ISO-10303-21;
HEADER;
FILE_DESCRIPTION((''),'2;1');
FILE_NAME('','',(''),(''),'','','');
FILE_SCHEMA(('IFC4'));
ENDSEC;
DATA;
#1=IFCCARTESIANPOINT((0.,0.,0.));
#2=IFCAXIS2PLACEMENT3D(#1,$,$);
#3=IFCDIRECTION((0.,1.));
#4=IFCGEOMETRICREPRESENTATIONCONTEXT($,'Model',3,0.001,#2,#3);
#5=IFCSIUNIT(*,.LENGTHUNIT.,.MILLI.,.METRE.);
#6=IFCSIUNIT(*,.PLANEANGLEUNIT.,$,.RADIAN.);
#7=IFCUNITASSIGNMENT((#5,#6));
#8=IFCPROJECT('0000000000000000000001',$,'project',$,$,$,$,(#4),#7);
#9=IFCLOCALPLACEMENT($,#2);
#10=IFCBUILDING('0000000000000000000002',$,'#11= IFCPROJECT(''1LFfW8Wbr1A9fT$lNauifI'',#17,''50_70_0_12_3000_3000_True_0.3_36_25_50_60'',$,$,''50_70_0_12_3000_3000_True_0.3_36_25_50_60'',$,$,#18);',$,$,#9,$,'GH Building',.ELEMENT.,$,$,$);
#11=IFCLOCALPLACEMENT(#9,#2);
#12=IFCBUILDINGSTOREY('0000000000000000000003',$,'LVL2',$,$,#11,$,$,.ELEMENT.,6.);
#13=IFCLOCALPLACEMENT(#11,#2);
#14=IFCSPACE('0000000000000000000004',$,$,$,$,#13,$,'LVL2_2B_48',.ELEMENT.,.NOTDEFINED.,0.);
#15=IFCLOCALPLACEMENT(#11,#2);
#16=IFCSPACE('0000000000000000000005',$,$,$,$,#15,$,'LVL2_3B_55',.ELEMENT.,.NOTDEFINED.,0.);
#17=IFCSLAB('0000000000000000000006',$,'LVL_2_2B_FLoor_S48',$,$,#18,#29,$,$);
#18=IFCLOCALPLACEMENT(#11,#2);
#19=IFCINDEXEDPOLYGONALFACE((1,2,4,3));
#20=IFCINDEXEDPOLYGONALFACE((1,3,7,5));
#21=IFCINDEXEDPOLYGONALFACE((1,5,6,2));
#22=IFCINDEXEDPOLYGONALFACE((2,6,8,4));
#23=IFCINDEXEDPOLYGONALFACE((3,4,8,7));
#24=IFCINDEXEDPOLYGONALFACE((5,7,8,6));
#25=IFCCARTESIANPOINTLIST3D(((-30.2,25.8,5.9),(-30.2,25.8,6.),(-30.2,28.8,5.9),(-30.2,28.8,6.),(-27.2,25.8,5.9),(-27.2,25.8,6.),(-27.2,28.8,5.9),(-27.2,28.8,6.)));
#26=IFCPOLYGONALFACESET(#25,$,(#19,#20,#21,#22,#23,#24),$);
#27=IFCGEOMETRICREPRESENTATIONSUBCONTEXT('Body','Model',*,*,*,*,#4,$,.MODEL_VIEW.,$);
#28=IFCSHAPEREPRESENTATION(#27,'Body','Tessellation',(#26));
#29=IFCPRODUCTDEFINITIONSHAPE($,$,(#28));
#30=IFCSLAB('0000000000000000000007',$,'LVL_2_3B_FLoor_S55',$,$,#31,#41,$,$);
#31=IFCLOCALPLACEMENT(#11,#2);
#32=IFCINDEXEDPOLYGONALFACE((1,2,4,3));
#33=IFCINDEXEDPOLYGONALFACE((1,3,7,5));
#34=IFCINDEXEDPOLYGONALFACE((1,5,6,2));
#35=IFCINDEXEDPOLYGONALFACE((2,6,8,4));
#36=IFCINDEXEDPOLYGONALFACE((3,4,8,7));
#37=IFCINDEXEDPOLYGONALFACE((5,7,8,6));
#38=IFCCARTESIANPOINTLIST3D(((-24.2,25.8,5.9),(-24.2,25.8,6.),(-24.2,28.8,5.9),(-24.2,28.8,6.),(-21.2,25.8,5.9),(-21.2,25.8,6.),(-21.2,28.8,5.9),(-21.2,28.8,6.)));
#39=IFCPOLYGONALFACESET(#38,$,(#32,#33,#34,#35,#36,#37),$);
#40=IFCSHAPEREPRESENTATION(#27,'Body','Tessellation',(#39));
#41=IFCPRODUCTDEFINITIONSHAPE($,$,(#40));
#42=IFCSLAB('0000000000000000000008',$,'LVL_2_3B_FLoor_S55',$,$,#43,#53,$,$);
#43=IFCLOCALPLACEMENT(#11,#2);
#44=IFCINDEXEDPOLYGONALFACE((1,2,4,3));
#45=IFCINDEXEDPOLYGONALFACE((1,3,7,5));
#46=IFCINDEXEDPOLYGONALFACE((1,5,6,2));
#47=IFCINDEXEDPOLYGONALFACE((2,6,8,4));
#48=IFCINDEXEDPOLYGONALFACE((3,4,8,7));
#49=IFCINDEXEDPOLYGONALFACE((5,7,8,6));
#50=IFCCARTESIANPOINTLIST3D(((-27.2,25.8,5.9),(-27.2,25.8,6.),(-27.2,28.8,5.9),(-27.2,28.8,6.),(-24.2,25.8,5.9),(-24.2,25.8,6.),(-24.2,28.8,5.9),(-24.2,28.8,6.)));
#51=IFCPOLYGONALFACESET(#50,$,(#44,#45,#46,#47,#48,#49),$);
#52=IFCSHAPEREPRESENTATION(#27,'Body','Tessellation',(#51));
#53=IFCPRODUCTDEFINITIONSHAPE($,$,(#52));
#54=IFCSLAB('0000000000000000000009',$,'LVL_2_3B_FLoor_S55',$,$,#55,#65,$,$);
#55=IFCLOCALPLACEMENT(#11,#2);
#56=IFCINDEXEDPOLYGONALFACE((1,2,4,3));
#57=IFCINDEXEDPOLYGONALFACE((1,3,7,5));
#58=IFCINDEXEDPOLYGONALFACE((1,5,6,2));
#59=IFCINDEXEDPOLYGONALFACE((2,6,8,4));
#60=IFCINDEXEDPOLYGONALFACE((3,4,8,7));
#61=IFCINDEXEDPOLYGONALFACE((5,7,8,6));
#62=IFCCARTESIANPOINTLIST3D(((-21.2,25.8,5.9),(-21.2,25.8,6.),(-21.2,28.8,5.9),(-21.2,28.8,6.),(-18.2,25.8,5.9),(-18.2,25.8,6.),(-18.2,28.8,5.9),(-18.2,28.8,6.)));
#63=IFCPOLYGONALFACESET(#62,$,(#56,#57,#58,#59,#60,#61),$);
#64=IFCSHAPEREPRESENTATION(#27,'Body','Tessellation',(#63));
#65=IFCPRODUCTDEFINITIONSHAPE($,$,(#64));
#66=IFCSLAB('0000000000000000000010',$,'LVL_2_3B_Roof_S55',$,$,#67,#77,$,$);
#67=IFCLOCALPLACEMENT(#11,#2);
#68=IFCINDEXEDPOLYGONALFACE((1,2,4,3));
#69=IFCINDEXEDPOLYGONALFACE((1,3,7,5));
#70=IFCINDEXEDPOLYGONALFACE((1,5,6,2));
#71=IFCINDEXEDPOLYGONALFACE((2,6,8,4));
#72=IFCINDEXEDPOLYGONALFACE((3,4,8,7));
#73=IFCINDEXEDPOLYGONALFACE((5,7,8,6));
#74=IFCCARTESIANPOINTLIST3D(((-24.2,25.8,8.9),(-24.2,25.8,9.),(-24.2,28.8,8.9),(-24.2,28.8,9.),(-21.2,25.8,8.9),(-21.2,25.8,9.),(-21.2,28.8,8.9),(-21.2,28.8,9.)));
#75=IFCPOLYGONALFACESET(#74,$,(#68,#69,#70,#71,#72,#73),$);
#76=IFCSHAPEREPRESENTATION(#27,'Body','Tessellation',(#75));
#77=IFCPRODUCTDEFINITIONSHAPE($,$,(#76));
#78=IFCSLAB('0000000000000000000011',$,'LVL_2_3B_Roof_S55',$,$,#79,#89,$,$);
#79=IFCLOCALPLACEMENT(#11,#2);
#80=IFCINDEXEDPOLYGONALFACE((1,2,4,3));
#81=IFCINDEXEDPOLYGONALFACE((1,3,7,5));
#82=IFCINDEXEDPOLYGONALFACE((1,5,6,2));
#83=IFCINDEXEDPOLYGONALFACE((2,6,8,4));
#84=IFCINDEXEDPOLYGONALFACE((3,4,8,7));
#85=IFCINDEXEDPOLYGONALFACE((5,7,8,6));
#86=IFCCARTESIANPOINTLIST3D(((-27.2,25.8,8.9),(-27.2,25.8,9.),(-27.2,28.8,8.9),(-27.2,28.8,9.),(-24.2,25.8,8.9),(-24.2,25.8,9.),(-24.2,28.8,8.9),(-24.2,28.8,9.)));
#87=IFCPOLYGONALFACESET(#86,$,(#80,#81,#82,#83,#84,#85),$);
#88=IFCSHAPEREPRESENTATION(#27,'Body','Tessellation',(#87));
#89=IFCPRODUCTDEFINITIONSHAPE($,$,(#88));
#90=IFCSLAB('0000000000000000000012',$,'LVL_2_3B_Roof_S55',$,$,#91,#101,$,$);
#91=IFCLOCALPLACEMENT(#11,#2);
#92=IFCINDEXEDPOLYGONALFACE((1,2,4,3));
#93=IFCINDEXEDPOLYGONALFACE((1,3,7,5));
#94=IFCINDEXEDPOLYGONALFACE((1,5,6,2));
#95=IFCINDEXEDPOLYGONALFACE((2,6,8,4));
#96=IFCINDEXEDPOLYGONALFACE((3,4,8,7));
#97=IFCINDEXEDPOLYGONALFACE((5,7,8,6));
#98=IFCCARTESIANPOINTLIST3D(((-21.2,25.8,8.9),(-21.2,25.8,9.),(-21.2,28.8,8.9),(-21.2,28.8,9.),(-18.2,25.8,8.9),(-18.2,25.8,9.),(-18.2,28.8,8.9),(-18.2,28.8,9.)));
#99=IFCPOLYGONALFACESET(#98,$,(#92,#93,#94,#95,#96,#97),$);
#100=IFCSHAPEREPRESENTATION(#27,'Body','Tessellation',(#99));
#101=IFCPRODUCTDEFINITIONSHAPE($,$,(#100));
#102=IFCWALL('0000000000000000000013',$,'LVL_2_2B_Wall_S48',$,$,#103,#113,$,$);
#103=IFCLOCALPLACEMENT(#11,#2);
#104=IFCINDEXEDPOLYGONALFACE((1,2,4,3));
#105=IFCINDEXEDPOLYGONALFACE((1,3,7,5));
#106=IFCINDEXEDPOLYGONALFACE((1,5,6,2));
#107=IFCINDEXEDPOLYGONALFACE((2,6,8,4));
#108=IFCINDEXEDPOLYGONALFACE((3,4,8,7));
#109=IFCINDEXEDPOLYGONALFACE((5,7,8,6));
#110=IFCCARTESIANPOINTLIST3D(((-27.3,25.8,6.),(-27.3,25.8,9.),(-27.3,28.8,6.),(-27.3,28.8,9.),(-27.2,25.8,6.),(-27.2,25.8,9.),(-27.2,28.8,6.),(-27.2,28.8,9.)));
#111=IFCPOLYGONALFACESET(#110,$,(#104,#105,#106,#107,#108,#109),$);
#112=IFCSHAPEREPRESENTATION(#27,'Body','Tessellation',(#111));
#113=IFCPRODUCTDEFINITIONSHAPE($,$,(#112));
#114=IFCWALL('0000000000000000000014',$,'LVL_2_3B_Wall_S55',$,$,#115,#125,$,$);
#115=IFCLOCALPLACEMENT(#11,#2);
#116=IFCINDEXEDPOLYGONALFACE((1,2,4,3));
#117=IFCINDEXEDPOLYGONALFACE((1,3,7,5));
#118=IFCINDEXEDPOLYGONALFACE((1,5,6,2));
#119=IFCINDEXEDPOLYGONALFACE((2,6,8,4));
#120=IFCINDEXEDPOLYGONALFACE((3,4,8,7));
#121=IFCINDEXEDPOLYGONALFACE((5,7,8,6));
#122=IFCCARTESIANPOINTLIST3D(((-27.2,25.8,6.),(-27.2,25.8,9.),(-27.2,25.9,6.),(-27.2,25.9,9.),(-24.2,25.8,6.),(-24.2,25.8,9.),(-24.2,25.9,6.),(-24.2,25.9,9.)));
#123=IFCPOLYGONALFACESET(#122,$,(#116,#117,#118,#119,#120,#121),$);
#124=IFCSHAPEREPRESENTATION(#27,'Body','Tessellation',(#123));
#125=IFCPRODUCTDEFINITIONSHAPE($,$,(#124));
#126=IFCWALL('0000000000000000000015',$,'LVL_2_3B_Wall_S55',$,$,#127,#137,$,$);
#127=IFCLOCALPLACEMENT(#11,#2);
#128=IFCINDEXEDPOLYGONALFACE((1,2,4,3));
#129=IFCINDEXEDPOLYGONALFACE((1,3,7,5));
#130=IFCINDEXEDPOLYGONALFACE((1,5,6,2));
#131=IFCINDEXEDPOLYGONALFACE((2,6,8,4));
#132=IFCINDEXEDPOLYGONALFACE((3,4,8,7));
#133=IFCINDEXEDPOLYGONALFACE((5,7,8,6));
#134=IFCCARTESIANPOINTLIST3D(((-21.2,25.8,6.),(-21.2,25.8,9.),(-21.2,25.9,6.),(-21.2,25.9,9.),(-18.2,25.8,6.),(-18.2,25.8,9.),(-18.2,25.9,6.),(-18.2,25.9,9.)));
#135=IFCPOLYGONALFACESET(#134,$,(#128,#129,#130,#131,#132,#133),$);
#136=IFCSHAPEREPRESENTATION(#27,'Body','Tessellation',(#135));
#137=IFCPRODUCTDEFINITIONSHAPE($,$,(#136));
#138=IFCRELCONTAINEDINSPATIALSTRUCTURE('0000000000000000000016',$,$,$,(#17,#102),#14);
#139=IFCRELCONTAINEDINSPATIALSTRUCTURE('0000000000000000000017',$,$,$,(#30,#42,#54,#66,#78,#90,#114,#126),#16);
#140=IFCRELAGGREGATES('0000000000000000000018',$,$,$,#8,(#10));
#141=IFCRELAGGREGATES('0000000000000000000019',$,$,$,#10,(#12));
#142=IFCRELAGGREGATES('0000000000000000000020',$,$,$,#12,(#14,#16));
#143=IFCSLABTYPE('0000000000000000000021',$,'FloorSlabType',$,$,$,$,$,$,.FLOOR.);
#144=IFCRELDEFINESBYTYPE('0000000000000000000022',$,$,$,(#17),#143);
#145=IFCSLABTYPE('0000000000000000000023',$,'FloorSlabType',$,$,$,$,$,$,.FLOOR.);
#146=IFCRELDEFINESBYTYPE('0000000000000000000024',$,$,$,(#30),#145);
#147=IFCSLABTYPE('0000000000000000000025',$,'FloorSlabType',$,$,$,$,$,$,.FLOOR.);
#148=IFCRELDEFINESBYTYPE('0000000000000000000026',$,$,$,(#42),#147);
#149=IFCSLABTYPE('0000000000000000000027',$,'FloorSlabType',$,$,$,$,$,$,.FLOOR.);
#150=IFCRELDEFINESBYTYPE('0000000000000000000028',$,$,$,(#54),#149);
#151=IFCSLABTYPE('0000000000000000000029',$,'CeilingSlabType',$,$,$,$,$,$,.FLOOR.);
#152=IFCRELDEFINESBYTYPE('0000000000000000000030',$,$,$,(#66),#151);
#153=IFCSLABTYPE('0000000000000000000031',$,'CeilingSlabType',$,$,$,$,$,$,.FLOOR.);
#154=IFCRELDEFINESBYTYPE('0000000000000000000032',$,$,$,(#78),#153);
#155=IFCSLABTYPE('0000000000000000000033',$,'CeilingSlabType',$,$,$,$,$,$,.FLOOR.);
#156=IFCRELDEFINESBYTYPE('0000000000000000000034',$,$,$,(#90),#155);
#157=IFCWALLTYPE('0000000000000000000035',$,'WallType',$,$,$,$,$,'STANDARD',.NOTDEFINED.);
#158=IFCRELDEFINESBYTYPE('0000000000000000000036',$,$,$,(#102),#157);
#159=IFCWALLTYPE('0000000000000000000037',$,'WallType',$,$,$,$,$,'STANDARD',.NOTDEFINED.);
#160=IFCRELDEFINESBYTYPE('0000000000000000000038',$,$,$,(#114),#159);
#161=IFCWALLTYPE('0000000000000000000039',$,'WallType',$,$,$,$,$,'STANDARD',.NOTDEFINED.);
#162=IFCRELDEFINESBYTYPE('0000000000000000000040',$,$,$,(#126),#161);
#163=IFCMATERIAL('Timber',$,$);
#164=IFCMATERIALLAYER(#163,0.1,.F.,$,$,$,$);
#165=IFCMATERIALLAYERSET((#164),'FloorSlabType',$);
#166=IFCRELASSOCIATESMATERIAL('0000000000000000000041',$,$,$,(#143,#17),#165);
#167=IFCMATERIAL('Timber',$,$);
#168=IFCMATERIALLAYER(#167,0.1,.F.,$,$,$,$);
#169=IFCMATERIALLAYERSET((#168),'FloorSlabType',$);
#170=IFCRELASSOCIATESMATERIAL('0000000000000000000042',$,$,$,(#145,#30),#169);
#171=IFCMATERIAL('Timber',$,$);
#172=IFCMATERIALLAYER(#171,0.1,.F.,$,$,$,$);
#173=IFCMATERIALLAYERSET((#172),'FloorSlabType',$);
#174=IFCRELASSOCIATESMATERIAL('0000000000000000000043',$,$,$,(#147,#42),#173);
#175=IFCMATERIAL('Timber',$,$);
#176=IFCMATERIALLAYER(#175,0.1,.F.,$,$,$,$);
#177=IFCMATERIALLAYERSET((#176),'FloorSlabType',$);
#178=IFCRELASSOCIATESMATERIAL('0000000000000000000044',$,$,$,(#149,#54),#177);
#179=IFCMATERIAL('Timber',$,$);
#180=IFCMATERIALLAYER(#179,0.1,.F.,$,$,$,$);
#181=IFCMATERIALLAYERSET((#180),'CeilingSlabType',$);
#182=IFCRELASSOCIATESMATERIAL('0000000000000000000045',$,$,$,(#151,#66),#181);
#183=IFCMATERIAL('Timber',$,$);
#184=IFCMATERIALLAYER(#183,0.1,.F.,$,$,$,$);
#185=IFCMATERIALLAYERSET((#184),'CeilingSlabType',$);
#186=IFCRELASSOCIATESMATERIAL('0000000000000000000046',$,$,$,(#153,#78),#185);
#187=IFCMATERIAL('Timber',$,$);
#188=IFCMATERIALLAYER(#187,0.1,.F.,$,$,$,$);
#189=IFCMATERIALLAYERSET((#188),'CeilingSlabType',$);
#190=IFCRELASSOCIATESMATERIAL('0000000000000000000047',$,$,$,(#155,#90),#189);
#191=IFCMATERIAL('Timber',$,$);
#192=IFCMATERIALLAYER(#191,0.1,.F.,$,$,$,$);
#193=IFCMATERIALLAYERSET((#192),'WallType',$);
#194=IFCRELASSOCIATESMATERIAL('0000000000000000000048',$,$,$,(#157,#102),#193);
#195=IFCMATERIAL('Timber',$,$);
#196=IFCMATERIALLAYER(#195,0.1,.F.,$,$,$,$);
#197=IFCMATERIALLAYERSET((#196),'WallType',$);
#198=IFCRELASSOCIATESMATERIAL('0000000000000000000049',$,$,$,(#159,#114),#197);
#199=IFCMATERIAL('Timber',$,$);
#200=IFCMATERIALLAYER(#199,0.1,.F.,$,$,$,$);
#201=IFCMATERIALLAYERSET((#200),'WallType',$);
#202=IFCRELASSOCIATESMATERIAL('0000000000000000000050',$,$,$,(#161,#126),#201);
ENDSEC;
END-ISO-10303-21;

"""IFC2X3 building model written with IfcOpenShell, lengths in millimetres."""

from ifc_helpers import new_model, si_unit, direction, frame, frame_2d, origin, place, context, subcontext, project, spatial, rectangle, extrude, material, layer, layer_set, layer_usage, type_object, element, save


model = new_model("IFC2X3")

# Units and contexts
model_context = context("Model", 3, precision=0.001, world=origin(), true_north=direction((0.0, 1.0)))
body_context = subcontext(model_context, "Body", "Model", "MODEL_VIEW")
ifc_project = project(units=[si_unit("LENGTHUNIT", "METRE", prefix="MILLI"), si_unit("PLANEANGLEUNIT", "RADIAN")], contexts=[model_context])

# Building, storey
building_placement = place(None, origin())
building = spatial("IfcBuilding", under=ifc_project, at=building_placement, Name="#11= IFCPROJECT('1LFfW8Wbr1A9fT$lNauifI',#17,'50_70_0_12_3000_3000_True_0.3_36_25_50_60',$,$,'50_70_0_12_3000_3000_True_0.3_36_25_50_60',$,$,#18);", LongName="GH Building", CompositionType="ELEMENT")
storey_placement = place(building_placement, origin())
storey = spatial("IfcBuildingStorey", under=building, at=storey_placement, Name="LVL2", CompositionType="ELEMENT", Elevation=6.0)

# Shared definitions
space_1_placement = place(storey_placement, origin())
space_1 = spatial("IfcSpace", under=storey, at=space_1_placement, LongName="LVL2_2B_48", CompositionType="ELEMENT", InteriorOrExteriorSpace="NOTDEFINED", ElevationWithFlooring=0.0)

# Slab
ifc_material_1 = material(Name="Timber")
ifc_layer_1 = layer(ifc_material_1, 0.1, ventilated=False)
ifc_layer_set_1 = layer_set([ifc_layer_1], Name="FloorSlabType")
ifc_layer_usage_1 = layer_usage(ifc_layer_set_1, "AXIS3", "NEGATIVE", -0.1)
slab_type_1 = type_object("IfcSlabType", Name="FloorSlabType", PredefinedType="FLOOR", material=ifc_layer_set_1)
slab_1_placement = place(space_1_placement, frame((-27.2, 28.8, 5.9), z_axis=(0.0, 0.0, 1.0), x_axis=(-1.0, 0.0, 0.0)))
element("IfcSlab", 1, at=slab_1_placement, inside=space_1, type_object=slab_type_1, material=ifc_layer_usage_1, Name="LVL_2_2B_FLoor_S48", context=body_context, shape_type="SweptSolid", body=[
    extrude(rectangle(XDim=3.0, YDim=3.0, at=frame_2d((1.5, 1.5))), origin(), (0.0, 0.0, 1.0), 0.1),
])

# Shared definitions
space_2_placement = place(storey_placement, origin())
space_2 = spatial("IfcSpace", under=storey, at=space_2_placement, LongName="LVL2_3B_55", CompositionType="ELEMENT", InteriorOrExteriorSpace="NOTDEFINED", ElevationWithFlooring=0.0)

# Slabs
ifc_material_2 = material(Name="Timber")
ifc_layer_2 = layer(ifc_material_2, 0.1, ventilated=False)
ifc_layer_set_2 = layer_set([ifc_layer_2], Name="FloorSlabType")
ifc_layer_usage_2 = layer_usage(ifc_layer_set_2, "AXIS3", "NEGATIVE", -0.1)
slab_type_2 = type_object("IfcSlabType", Name="FloorSlabType", PredefinedType="FLOOR", material=ifc_layer_set_2)
slab_2_placement = place(space_2_placement, frame((-21.2, 28.8, 5.9), z_axis=(0.0, 0.0, 1.0), x_axis=(-1.0, 0.0, 0.0)))
element("IfcSlab", 2, at=slab_2_placement, inside=space_2, type_object=slab_type_2, material=ifc_layer_usage_2, Name="LVL_2_3B_FLoor_S55", context=body_context, shape_type="SweptSolid", body=[
    extrude(rectangle(XDim=3.0, YDim=3.0, at=frame_2d((1.5, 1.5))), origin(), (0.0, 0.0, 1.0), 0.1),
])
ifc_material_3 = material(Name="Timber")
ifc_layer_3 = layer(ifc_material_3, 0.1, ventilated=False)
ifc_layer_set_3 = layer_set([ifc_layer_3], Name="FloorSlabType")
ifc_layer_usage_3 = layer_usage(ifc_layer_set_3, "AXIS3", "NEGATIVE", -0.1)
slab_type_3 = type_object("IfcSlabType", Name="FloorSlabType", PredefinedType="FLOOR", material=ifc_layer_set_3)
slab_3_placement = place(space_2_placement, frame((-24.2, 28.8, 5.9), z_axis=(0.0, 0.0, 1.0), x_axis=(-1.0, 0.0, 0.0)))
element("IfcSlab", 3, at=slab_3_placement, inside=space_2, type_object=slab_type_3, material=ifc_layer_usage_3, Name="LVL_2_3B_FLoor_S55", context=body_context, shape_type="SweptSolid", body=[
    extrude(rectangle(XDim=3.0, YDim=3.0, at=frame_2d((1.5, 1.5))), origin(), (0.0, 0.0, 1.0), 0.1),
])
ifc_material_4 = material(Name="Timber")
ifc_layer_4 = layer(ifc_material_4, 0.1, ventilated=False)
ifc_layer_set_4 = layer_set([ifc_layer_4], Name="FloorSlabType")
ifc_layer_usage_4 = layer_usage(ifc_layer_set_4, "AXIS3", "NEGATIVE", -0.1)
slab_type_4 = type_object("IfcSlabType", Name="FloorSlabType", PredefinedType="FLOOR", material=ifc_layer_set_4)
slab_4_placement = place(space_2_placement, frame((-18.2, 28.8, 5.9), z_axis=(0.0, 0.0, 1.0), x_axis=(-1.0, 0.0, 0.0)))
element("IfcSlab", 4, at=slab_4_placement, inside=space_2, type_object=slab_type_4, material=ifc_layer_usage_4, Name="LVL_2_3B_FLoor_S55", context=body_context, shape_type="SweptSolid", body=[
    extrude(rectangle(XDim=3.0, YDim=3.0, at=frame_2d((1.5, 1.5))), origin(), (0.0, 0.0, 1.0), 0.1),
])
ifc_material_5 = material(Name="Timber")
ifc_layer_5 = layer(ifc_material_5, 0.1, ventilated=False)
ifc_layer_set_5 = layer_set([ifc_layer_5], Name="CeilingSlabType")
ifc_layer_usage_5 = layer_usage(ifc_layer_set_5, "AXIS3", "NEGATIVE", -0.1)
slab_type_5 = type_object("IfcSlabType", Name="CeilingSlabType", PredefinedType="FLOOR", material=ifc_layer_set_5)
slab_5_placement = place(space_2_placement, frame((-21.2, 28.8, 8.9), z_axis=(0.0, 0.0, 1.0), x_axis=(-1.0, 0.0, 0.0)))
element("IfcSlab", 5, at=slab_5_placement, inside=space_2, type_object=slab_type_5, material=ifc_layer_usage_5, Name="LVL_2_3B_Roof_S55", context=body_context, shape_type="SweptSolid", body=[
    extrude(rectangle(XDim=3.0, YDim=3.0, at=frame_2d((1.5, 1.5))), origin(), (0.0, 0.0, 1.0), 0.1),
])
ifc_material_6 = material(Name="Timber")
ifc_layer_6 = layer(ifc_material_6, 0.1, ventilated=False)
ifc_layer_set_6 = layer_set([ifc_layer_6], Name="CeilingSlabType")
ifc_layer_usage_6 = layer_usage(ifc_layer_set_6, "AXIS3", "NEGATIVE", -0.1)
slab_type_6 = type_object("IfcSlabType", Name="CeilingSlabType", PredefinedType="FLOOR", material=ifc_layer_set_6)
slab_6_placement = place(space_2_placement, frame((-24.2, 28.8, 8.9), z_axis=(0.0, 0.0, 1.0), x_axis=(-1.0, 0.0, 0.0)))
element("IfcSlab", 6, at=slab_6_placement, inside=space_2, type_object=slab_type_6, material=ifc_layer_usage_6, Name="LVL_2_3B_Roof_S55", context=body_context, shape_type="SweptSolid", body=[
    extrude(rectangle(XDim=3.0, YDim=3.0, at=frame_2d((1.5, 1.5))), origin(), (0.0, 0.0, 1.0), 0.1),
])
ifc_material_7 = material(Name="Timber")
ifc_layer_7 = layer(ifc_material_7, 0.1, ventilated=False)
ifc_layer_set_7 = layer_set([ifc_layer_7], Name="CeilingSlabType")
ifc_layer_usage_7 = layer_usage(ifc_layer_set_7, "AXIS3", "NEGATIVE", -0.1)
slab_type_7 = type_object("IfcSlabType", Name="CeilingSlabType", PredefinedType="FLOOR", material=ifc_layer_set_7)
slab_7_placement = place(space_2_placement, frame((-18.2, 28.8, 8.9), z_axis=(0.0, 0.0, 1.0), x_axis=(-1.0, 0.0, 0.0)))
element("IfcSlab", 7, at=slab_7_placement, inside=space_2, type_object=slab_type_7, material=ifc_layer_usage_7, Name="LVL_2_3B_Roof_S55", context=body_context, shape_type="SweptSolid", body=[
    extrude(rectangle(XDim=3.0, YDim=3.0, at=frame_2d((1.5, 1.5))), origin(), (0.0, 0.0, 1.0), 0.1),
])

# Wall
ifc_material_8 = material(Name="Timber")
ifc_layer_8 = layer(ifc_material_8, 0.1, ventilated=False)
ifc_layer_set_8 = layer_set([ifc_layer_8], Name="WallType")
ifc_layer_usage_8 = layer_usage(ifc_layer_set_8, "AXIS2", "NEGATIVE", 0.0)
wall_type_1 = type_object("IfcWallType", Name="WallType", ElementType="STANDARD", PredefinedType="NOTDEFINED", material=ifc_layer_set_8)
wall_1_placement = place(space_1_placement, frame((-27.2, 28.8, 6.0), z_axis=(0.0, 0.0, 1.0), x_axis=(0.0, -1.0, 0.0)))
element("IfcWall", 8, at=wall_1_placement, inside=space_1, type_object=wall_type_1, material=ifc_layer_usage_8, Name="LVL_2_2B_Wall_S48", context=body_context, shape_type="SweptSolid", body=[
    extrude(rectangle(XDim=3.0, YDim=0.1, at=frame_2d((1.5, -0.1))), origin(), (0.0, 0.0, 1.0), 3.0),
])

# Walls
ifc_material_9 = material(Name="Timber")
ifc_layer_9 = layer(ifc_material_9, 0.1, ventilated=False)
ifc_layer_set_9 = layer_set([ifc_layer_9], Name="WallType")
ifc_layer_usage_9 = layer_usage(ifc_layer_set_9, "AXIS2", "NEGATIVE", 0.0)
wall_type_2 = type_object("IfcWallType", Name="WallType", ElementType="STANDARD", PredefinedType="NOTDEFINED", material=ifc_layer_set_9)
wall_2_placement = place(space_2_placement, frame((-24.2, 25.8, 6.0), z_axis=(0.0, 0.0, 1.0), x_axis=(-1.0, 0.0, 0.0)))
element("IfcWall", 9, at=wall_2_placement, inside=space_2, type_object=wall_type_2, material=ifc_layer_usage_9, Name="LVL_2_3B_Wall_S55", context=body_context, shape_type="SweptSolid", body=[
    extrude(rectangle(XDim=3.0, YDim=0.1, at=frame_2d((1.5, -0.1))), origin(), (0.0, 0.0, 1.0), 3.0),
])
ifc_material_10 = material(Name="Timber")
ifc_layer_10 = layer(ifc_material_10, 0.1, ventilated=False)
ifc_layer_set_10 = layer_set([ifc_layer_10], Name="WallType")
ifc_layer_usage_10 = layer_usage(ifc_layer_set_10, "AXIS2", "NEGATIVE", 0.0)
wall_type_3 = type_object("IfcWallType", Name="WallType", ElementType="STANDARD", PredefinedType="NOTDEFINED", material=ifc_layer_set_10)
wall_3_placement = place(space_2_placement, frame((-18.2, 25.8, 6.0), z_axis=(0.0, 0.0, 1.0), x_axis=(-1.0, 0.0, 0.0)))
element("IfcWall", 10, at=wall_3_placement, inside=space_2, type_object=wall_type_3, material=ifc_layer_usage_10, Name="LVL_2_3B_Wall_S55", context=body_context, shape_type="SweptSolid", body=[
    extrude(rectangle(XDim=3.0, YDim=0.1, at=frame_2d((1.5, -0.1))), origin(), (0.0, 0.0, 1.0), 3.0),
])

save(model, "model.ifc")
